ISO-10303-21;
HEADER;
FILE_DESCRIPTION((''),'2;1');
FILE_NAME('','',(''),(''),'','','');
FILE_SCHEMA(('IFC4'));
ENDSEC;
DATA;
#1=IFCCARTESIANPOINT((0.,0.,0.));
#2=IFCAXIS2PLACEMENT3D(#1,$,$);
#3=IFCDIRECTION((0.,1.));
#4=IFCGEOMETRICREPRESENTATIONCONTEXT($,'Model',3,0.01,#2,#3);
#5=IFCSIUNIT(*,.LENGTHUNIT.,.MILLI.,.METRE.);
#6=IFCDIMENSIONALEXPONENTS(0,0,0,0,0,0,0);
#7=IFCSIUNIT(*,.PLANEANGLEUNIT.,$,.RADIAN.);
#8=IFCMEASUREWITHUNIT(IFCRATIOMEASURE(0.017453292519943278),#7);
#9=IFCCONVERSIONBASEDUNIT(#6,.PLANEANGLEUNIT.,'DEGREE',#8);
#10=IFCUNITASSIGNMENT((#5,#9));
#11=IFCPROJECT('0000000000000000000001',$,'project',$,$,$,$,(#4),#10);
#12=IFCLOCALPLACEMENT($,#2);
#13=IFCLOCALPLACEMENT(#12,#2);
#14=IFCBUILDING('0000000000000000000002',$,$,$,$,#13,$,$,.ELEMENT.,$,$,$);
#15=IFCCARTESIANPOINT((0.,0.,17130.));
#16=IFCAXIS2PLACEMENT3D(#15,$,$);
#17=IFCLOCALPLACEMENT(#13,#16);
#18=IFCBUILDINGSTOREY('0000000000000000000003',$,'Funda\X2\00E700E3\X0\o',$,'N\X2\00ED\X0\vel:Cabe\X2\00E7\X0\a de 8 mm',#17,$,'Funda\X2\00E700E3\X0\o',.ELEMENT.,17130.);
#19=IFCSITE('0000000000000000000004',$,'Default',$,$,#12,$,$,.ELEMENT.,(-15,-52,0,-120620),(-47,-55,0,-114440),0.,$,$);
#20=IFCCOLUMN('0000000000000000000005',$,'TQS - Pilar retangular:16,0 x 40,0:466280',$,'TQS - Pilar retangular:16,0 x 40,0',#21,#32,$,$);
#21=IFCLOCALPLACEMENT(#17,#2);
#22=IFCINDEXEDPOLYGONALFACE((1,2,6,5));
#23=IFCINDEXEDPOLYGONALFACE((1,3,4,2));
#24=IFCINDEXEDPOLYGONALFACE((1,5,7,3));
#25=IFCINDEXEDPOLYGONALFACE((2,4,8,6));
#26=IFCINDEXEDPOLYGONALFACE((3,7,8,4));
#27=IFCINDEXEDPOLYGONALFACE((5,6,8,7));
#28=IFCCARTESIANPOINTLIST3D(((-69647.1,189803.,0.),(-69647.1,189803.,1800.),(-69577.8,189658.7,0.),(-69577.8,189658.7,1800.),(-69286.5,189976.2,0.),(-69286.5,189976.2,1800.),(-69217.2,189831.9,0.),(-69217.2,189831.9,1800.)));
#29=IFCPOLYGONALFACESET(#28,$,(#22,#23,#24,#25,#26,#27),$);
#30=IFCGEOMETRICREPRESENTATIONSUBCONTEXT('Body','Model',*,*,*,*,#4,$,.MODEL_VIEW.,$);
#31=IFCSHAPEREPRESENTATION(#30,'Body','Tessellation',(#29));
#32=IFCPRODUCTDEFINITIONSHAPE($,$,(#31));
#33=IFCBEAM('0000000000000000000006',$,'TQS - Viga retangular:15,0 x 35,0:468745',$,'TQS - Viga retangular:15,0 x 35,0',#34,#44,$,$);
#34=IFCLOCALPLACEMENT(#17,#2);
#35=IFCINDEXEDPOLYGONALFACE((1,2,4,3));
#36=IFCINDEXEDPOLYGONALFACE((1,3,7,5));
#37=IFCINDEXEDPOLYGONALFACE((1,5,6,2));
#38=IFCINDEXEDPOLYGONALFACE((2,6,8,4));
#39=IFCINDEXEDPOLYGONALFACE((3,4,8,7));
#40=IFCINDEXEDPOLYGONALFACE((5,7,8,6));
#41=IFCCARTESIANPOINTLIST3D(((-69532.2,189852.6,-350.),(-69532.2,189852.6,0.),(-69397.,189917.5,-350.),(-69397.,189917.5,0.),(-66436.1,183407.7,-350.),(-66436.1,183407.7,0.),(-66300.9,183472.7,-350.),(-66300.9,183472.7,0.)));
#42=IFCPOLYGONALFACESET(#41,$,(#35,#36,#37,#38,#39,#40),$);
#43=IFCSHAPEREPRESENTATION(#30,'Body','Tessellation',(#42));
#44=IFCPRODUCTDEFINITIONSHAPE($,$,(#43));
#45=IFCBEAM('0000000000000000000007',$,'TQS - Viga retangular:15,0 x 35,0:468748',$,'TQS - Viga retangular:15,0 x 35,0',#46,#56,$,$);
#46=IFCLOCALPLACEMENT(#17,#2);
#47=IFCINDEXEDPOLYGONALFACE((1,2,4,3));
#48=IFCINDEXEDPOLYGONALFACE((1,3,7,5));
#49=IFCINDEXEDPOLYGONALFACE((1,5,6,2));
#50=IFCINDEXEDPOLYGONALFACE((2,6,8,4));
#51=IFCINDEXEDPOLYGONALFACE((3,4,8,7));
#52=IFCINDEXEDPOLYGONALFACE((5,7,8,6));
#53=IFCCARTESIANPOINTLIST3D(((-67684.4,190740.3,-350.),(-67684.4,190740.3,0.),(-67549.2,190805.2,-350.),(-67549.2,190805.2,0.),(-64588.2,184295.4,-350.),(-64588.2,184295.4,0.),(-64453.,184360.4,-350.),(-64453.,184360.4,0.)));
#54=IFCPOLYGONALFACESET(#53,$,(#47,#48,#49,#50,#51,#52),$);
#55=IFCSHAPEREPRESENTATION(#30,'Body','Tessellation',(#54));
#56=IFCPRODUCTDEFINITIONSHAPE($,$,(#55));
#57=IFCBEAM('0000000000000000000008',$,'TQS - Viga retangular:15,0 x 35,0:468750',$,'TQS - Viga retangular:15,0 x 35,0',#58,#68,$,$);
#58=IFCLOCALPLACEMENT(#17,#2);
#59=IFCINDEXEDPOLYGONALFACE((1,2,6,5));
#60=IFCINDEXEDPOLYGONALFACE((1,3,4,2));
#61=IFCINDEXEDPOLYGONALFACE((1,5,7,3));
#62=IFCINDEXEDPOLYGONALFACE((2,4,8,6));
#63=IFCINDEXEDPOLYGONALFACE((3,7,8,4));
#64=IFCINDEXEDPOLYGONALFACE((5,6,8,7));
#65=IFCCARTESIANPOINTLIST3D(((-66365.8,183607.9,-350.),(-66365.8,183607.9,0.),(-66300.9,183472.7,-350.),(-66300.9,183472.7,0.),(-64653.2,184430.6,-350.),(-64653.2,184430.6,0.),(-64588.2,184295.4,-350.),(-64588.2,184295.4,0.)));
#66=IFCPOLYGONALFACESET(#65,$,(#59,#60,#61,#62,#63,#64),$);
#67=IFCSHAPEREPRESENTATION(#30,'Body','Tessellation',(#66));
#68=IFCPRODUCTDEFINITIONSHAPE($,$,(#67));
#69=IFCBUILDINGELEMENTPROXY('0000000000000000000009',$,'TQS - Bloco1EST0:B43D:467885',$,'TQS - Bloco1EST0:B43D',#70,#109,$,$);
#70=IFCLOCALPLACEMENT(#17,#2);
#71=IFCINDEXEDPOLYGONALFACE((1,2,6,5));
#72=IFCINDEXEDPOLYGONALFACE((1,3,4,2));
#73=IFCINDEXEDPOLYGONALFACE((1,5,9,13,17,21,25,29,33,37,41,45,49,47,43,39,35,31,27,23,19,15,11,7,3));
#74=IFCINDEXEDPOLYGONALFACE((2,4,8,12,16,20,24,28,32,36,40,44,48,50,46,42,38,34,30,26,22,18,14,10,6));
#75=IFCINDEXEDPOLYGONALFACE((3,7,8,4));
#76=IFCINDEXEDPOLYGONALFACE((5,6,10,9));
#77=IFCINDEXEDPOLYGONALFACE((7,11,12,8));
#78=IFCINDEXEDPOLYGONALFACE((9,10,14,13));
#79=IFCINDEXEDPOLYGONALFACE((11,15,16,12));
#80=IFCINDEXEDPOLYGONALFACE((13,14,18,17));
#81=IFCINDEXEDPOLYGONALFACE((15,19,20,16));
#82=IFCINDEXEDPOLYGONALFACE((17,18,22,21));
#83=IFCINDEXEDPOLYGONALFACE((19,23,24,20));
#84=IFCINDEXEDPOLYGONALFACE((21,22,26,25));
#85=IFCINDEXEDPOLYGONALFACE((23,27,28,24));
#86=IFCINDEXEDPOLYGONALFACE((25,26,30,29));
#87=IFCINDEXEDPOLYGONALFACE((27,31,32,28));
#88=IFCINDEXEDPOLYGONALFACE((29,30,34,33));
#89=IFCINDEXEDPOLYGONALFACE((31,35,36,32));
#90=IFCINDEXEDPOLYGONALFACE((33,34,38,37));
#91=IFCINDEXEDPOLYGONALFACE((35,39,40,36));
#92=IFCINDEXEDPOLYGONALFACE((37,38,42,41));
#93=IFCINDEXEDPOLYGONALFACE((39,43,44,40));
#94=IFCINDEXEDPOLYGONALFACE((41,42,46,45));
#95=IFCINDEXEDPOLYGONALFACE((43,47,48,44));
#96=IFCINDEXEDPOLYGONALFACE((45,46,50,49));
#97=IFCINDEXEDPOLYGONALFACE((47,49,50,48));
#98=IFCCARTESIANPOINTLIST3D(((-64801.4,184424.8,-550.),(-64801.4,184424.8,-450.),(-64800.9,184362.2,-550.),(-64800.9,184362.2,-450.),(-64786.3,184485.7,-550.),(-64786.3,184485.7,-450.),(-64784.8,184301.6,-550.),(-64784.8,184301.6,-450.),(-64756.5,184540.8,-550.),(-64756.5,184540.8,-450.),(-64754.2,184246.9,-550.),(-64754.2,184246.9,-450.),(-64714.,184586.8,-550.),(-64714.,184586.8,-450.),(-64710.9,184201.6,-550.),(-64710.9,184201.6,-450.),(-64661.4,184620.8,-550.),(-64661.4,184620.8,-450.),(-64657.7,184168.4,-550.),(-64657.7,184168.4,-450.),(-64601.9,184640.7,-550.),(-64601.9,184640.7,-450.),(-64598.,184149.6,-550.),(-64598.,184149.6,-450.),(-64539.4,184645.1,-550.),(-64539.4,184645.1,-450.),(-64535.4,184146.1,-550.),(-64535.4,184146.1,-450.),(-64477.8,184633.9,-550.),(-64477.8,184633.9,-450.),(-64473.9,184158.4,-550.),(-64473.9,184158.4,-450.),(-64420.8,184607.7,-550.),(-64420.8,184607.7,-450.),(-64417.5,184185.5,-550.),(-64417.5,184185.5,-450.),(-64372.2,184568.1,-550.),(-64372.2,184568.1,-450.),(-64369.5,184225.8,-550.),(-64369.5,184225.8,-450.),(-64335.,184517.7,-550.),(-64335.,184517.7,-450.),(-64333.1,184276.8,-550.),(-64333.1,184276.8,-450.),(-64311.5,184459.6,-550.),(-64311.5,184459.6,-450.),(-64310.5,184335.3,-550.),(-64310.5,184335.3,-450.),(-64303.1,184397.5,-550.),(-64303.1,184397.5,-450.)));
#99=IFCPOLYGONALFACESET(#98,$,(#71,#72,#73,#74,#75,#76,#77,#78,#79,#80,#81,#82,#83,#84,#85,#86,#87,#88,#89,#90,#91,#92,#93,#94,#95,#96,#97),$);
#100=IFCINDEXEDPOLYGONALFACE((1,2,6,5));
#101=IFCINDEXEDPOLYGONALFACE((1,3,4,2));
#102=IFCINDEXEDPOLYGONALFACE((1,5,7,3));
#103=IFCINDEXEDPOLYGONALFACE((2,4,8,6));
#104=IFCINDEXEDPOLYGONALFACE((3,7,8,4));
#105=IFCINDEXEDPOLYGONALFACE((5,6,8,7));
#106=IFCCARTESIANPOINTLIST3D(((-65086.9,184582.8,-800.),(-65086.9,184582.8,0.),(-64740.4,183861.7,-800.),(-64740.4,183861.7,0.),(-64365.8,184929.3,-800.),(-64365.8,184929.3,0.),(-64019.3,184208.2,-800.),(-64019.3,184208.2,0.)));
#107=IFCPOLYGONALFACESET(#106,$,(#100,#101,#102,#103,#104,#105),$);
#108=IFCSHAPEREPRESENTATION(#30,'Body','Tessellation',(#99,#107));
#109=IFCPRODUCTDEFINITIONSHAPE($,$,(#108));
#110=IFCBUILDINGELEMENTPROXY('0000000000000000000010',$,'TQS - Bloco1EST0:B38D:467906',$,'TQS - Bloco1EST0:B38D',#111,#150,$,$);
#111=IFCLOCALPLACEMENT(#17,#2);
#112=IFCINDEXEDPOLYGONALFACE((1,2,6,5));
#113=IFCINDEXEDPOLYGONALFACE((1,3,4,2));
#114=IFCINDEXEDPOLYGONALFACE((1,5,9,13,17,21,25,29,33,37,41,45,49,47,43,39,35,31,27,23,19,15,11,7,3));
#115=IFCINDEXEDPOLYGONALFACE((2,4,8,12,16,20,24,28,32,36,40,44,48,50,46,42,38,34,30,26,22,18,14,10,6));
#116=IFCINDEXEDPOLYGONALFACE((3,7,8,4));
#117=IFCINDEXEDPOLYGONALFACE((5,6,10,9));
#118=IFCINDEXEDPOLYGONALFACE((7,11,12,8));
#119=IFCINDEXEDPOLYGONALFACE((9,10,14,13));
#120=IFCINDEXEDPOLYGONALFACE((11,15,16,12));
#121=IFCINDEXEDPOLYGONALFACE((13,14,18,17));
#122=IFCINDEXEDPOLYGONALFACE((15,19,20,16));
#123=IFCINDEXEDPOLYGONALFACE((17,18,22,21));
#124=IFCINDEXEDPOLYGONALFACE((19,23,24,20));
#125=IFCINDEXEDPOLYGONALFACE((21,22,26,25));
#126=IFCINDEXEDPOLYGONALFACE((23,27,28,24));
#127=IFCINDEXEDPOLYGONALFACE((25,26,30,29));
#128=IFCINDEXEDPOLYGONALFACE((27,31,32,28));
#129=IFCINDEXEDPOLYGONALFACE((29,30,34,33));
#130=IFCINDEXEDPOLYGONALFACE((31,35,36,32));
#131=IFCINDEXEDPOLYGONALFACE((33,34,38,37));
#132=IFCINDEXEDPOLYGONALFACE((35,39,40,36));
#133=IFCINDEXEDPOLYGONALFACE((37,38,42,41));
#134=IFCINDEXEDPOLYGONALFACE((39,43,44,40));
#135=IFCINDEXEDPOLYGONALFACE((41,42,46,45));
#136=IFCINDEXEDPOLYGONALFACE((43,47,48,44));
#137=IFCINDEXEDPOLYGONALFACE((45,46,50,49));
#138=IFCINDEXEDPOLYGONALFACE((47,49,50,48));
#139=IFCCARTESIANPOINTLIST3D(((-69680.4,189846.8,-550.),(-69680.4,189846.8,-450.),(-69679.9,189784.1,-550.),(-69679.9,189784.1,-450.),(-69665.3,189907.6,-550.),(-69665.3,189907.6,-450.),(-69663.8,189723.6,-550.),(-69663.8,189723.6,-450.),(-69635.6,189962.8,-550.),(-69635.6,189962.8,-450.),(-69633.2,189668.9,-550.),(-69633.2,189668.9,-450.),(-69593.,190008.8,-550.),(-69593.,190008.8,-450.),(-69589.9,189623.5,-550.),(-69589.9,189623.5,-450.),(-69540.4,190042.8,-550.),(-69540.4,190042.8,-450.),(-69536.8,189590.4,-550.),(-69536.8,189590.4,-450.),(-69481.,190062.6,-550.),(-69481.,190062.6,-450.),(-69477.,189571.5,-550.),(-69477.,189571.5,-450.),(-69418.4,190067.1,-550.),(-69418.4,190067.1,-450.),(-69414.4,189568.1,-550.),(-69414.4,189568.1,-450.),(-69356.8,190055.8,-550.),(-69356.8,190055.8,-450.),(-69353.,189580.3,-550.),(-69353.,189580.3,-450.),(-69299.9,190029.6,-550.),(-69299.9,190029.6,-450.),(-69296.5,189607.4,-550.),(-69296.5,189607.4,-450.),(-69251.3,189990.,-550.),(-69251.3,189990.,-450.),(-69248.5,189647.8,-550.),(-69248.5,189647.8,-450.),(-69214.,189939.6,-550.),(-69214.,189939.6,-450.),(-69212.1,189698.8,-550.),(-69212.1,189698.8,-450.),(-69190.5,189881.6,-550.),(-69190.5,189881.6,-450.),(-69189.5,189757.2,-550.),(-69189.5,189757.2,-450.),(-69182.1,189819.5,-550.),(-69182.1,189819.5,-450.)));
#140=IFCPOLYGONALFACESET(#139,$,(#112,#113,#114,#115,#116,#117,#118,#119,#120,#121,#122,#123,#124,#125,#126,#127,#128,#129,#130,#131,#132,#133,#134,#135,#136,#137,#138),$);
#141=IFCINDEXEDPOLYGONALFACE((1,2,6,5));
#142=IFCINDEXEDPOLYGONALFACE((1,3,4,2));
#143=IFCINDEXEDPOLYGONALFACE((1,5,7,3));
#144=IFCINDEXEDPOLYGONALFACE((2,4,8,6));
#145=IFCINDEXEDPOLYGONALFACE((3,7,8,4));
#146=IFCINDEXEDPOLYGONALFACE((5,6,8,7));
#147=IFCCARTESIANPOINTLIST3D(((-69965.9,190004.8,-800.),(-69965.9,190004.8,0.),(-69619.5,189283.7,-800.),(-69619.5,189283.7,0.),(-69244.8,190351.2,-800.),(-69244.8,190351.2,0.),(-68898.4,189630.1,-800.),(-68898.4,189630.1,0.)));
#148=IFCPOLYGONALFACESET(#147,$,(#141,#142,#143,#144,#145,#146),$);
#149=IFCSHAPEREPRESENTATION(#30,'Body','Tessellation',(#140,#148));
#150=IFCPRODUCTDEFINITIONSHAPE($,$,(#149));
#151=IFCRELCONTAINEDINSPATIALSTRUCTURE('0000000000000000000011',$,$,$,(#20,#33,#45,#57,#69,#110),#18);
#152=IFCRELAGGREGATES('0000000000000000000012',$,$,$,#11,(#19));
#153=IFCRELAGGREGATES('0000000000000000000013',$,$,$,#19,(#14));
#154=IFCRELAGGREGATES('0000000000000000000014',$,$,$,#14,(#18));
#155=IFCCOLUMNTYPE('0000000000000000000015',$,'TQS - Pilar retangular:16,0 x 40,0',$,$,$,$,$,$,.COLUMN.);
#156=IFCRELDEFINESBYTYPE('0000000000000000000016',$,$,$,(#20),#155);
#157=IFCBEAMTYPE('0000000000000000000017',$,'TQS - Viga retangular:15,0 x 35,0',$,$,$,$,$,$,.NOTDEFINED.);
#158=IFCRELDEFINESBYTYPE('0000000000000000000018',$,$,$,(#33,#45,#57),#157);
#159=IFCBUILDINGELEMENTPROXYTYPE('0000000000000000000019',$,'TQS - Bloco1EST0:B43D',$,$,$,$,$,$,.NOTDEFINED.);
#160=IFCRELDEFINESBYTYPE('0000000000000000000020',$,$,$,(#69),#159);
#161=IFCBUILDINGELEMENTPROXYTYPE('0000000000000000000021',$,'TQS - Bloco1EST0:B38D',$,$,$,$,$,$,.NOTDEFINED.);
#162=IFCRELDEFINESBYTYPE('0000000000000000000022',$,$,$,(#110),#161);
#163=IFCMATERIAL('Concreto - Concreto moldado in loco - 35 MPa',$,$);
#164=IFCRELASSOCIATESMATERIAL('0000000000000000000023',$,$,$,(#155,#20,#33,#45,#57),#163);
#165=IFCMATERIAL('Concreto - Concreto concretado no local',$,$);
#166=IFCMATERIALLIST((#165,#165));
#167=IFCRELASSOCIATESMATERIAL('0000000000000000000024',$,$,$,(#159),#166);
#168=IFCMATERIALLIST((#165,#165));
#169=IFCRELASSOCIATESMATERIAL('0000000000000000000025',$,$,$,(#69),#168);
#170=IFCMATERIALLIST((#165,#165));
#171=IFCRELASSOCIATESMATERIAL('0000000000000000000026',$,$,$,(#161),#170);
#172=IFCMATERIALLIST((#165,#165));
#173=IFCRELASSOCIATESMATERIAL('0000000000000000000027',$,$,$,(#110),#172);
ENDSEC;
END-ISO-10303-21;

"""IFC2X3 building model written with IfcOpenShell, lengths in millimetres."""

from ifc_helpers import new_model, entity, si_unit, converted_unit, direction, frame, frame_2d, origin, origin_2d_with_axis, place, context, subcontext, project, spatial, rectangle, circle, extrude, source, transform, mapped, material, material_list, type_object, type_shapes, element, save


model = new_model("IFC2X3")

# Units and contexts
model_context = context("Model", 3, precision=0.01, world=origin(), true_north=direction((0.0, 1.0)))
body_context = subcontext(model_context, "Body", "Model", "MODEL_VIEW")
ifc_project = project(units=[si_unit("LENGTHUNIT", "METRE", prefix="MILLI"), converted_unit("PLANEANGLEUNIT", "DEGREE", entity("IfcRatioMeasure", 0.017453292519943278), si_unit("PLANEANGLEUNIT", "RADIAN"), dimensions=[0, 0, 0, 0, 0, 0, 0])], contexts=[model_context])

# Site, building, storey
site_placement = place(None, origin())
site = spatial("IfcSite", under=ifc_project, at=site_placement, Name="Default", CompositionType="ELEMENT", RefLatitude=(-15, -52, 0, -120620), RefLongitude=(-47, -55, 0, -114440), RefElevation=0.0)
building_placement = place(site_placement, origin())
building = spatial("IfcBuilding", under=site, at=building_placement, CompositionType="ELEMENT")
storey_placement = place(building_placement, frame((0.0, 0.0, 17130.0)))
storey = spatial("IfcBuildingStorey", under=building, at=storey_placement, Name="Fundação", ObjectType="Nível:Cabeça de 8 mm", LongName="Fundação", CompositionType="ELEMENT", Elevation=17130.0)

# Column
ifc_material_1 = material(Name="Concreto - Concreto moldado in loco - 35 MPa")
column_type_1 = type_object("IfcColumnType", Name="TQS - Pilar retangular:16,0 x 40,0", PredefinedType="COLUMN", material=ifc_material_1)
shared_shape_1 = source(origin(), body_context, "Body", "SweptSolid", [
    extrude(rectangle(XDim=400.0, YDim=160.0, at=origin_2d_with_axis()), frame((-69432.1, 189817.4, 17130.0), z_axis=(0.0, 0.0, 1.0), x_axis=(-0.90138, -0.43303, 0.0)), (0.0, 0.0, 1.0), 1800.0),
])
type_shapes(column_type_1, [shared_shape_1])
column_1_placement = place(storey_placement, frame((0.0, 0.0, -17130.0)))
element("IfcColumn", 1, at=column_1_placement, inside=storey, type_object=column_type_1, material=ifc_material_1, Name="TQS - Pilar retangular:16,0 x 40,0:466280", ObjectType="TQS - Pilar retangular:16,0 x 40,0", context=body_context, shape_type="MappedRepresentation", body=[
    mapped(shared_shape_1, transform((0.0, 0.0, 0.0), scale=1.0)),
])

# Beams
beam_type = type_object("IfcBeamType", Name="TQS - Viga retangular:15,0 x 35,0", PredefinedType="NOTDEFINED")
beam_1_placement = place(storey_placement, frame((-66400.9, 183507.8, 0.0), z_axis=(0.0, 0.0, 1.0), x_axis=(-0.43303, 0.90138, 0.0)))
element("IfcBeam", 2, at=beam_1_placement, inside=storey, type_object=beam_type, material=ifc_material_1, Name="TQS - Viga retangular:15,0 x 35,0:468745", ObjectType="TQS - Viga retangular:15,0 x 35,0", context=body_context, shape_type="SweptSolid", body=[
    extrude(rectangle(XDim=350.0, YDim=150.0, at=frame_2d((0.0, 0.0), x_axis=(1.0, 0.0))), frame((-75.0, 0.0, -175.0), z_axis=(1.0, 0.0, 0.0), x_axis=(0.0, 0.0, -1.0)), (0.0, 0.0, 1.0), 7150.0),
])
beam_2_placement = place(storey_placement, frame((-64553.1, 184395.5, 0.0), z_axis=(0.0, 0.0, 1.0), x_axis=(-0.43303, 0.90138, 0.0)))
element("IfcBeam", 3, at=beam_2_placement, inside=storey, type_object=beam_type, material=ifc_material_1, Name="TQS - Viga retangular:15,0 x 35,0:468748", ObjectType="TQS - Viga retangular:15,0 x 35,0", context=body_context, shape_type="SweptSolid", body=[
    extrude(rectangle(XDim=350.0, YDim=150.0, at=frame_2d((0.0, 0.0), x_axis=(1.0, 0.0))), frame((-75.0, 0.0, -175.0), z_axis=(1.0, 0.0, 0.0), x_axis=(0.0, 0.0, -1.0)), (0.0, 0.0, 1.0), 7150.0),
])
beam_3_placement = place(storey_placement, frame((-64553.1, 184395.5, 0.0), z_axis=(0.0, 0.0, 1.0), x_axis=(-0.90138, -0.43303, 0.0)))
element("IfcBeam", 4, at=beam_3_placement, inside=storey, type_object=beam_type, material=ifc_material_1, Name="TQS - Viga retangular:15,0 x 35,0:468750", ObjectType="TQS - Viga retangular:15,0 x 35,0", context=body_context, shape_type="SweptSolid", body=[
    extrude(rectangle(XDim=350.0, YDim=150.0, at=frame_2d((0.0, 0.0), x_axis=(1.0, 0.0))), frame((75.0, 0.0, -175.0), z_axis=(1.0, 0.0, 0.0), x_axis=(0.0, 0.0, -1.0)), (0.0, 0.0, 1.0), 1900.0),
])

# Building element proxies
ifc_material_2 = material(Name="Concreto - Concreto concretado no local")
ifc_material_list_1 = material_list([ifc_material_2, ifc_material_2])
ifc_material_list_2 = material_list([ifc_material_2, ifc_material_2])
building_element_proxy_type_1 = type_object("IfcBuildingElementProxyType", Name="TQS - Bloco1EST0:B43D", PredefinedType="NOTDEFINED", material=ifc_material_list_2)
shared_shape_2 = source(origin(), body_context, "Body", "SweptSolid", [
    extrude(circle(Radius=250.0, at=frame_2d((0.0, 0.0), x_axis=(1.0, 0.0))), frame((0.0, 0.0, -550.0)), (0.0, 0.0, 1.0), 100.0),
    extrude(rectangle(XDim=800.0, YDim=800.0, at=origin_2d_with_axis()), frame((0.0, 0.0, -800.0), z_axis=(0.0, 0.0, 1.0), x_axis=(-1.0, 0.0, 0.0)), (0.0, 0.0, 1.0), 800.0),
])
type_shapes(building_element_proxy_type_1, [shared_shape_2])
proxy_1_placement = place(storey_placement, frame((-64553.1, 184395.5, 0.0), z_axis=(0.0, 0.0, 1.0), x_axis=(-0.43303, 0.90138, 0.0)))
element("IfcBuildingElementProxy", 5, at=proxy_1_placement, inside=storey, type_object=building_element_proxy_type_1, material=ifc_material_list_1, Name="TQS - Bloco1EST0:B43D:467885", ObjectType="TQS - Bloco1EST0:B43D", context=body_context, shape_type="MappedRepresentation", body=[
    mapped(shared_shape_2, transform((0.0, 0.0, 0.0), scale=1.0)),
])
ifc_material_list_3 = material_list([ifc_material_2, ifc_material_2])
ifc_material_list_4 = material_list([ifc_material_2, ifc_material_2])
building_element_proxy_type_2 = type_object("IfcBuildingElementProxyType", Name="TQS - Bloco1EST0:B38D", PredefinedType="NOTDEFINED", material=ifc_material_list_4)
shared_shape_3 = source(origin(), body_context, "Body", "SweptSolid", [
    extrude(circle(Radius=250.0, at=frame_2d((0.0, 0.0), x_axis=(1.0, 0.0))), frame((0.0, 0.0, -550.0)), (0.0, 0.0, 1.0), 100.0),
    extrude(rectangle(XDim=800.0, YDim=800.0, at=origin_2d_with_axis()), frame((0.0, 0.0, -800.0), z_axis=(0.0, 0.0, 1.0), x_axis=(-1.0, 0.0, 0.0)), (0.0, 0.0, 1.0), 800.0),
])
type_shapes(building_element_proxy_type_2, [shared_shape_3])
proxy_2_placement = place(storey_placement, frame((-69432.1, 189817.4, 0.0), z_axis=(0.0, 0.0, 1.0), x_axis=(-0.43303, 0.90138, 0.0)))
element("IfcBuildingElementProxy", 6, at=proxy_2_placement, inside=storey, type_object=building_element_proxy_type_2, material=ifc_material_list_3, Name="TQS - Bloco1EST0:B38D:467906", ObjectType="TQS - Bloco1EST0:B38D", context=body_context, shape_type="MappedRepresentation", body=[
    mapped(shared_shape_3, transform((0.0, 0.0, 0.0), scale=1.0)),
])

save(model, "model.ifc")
